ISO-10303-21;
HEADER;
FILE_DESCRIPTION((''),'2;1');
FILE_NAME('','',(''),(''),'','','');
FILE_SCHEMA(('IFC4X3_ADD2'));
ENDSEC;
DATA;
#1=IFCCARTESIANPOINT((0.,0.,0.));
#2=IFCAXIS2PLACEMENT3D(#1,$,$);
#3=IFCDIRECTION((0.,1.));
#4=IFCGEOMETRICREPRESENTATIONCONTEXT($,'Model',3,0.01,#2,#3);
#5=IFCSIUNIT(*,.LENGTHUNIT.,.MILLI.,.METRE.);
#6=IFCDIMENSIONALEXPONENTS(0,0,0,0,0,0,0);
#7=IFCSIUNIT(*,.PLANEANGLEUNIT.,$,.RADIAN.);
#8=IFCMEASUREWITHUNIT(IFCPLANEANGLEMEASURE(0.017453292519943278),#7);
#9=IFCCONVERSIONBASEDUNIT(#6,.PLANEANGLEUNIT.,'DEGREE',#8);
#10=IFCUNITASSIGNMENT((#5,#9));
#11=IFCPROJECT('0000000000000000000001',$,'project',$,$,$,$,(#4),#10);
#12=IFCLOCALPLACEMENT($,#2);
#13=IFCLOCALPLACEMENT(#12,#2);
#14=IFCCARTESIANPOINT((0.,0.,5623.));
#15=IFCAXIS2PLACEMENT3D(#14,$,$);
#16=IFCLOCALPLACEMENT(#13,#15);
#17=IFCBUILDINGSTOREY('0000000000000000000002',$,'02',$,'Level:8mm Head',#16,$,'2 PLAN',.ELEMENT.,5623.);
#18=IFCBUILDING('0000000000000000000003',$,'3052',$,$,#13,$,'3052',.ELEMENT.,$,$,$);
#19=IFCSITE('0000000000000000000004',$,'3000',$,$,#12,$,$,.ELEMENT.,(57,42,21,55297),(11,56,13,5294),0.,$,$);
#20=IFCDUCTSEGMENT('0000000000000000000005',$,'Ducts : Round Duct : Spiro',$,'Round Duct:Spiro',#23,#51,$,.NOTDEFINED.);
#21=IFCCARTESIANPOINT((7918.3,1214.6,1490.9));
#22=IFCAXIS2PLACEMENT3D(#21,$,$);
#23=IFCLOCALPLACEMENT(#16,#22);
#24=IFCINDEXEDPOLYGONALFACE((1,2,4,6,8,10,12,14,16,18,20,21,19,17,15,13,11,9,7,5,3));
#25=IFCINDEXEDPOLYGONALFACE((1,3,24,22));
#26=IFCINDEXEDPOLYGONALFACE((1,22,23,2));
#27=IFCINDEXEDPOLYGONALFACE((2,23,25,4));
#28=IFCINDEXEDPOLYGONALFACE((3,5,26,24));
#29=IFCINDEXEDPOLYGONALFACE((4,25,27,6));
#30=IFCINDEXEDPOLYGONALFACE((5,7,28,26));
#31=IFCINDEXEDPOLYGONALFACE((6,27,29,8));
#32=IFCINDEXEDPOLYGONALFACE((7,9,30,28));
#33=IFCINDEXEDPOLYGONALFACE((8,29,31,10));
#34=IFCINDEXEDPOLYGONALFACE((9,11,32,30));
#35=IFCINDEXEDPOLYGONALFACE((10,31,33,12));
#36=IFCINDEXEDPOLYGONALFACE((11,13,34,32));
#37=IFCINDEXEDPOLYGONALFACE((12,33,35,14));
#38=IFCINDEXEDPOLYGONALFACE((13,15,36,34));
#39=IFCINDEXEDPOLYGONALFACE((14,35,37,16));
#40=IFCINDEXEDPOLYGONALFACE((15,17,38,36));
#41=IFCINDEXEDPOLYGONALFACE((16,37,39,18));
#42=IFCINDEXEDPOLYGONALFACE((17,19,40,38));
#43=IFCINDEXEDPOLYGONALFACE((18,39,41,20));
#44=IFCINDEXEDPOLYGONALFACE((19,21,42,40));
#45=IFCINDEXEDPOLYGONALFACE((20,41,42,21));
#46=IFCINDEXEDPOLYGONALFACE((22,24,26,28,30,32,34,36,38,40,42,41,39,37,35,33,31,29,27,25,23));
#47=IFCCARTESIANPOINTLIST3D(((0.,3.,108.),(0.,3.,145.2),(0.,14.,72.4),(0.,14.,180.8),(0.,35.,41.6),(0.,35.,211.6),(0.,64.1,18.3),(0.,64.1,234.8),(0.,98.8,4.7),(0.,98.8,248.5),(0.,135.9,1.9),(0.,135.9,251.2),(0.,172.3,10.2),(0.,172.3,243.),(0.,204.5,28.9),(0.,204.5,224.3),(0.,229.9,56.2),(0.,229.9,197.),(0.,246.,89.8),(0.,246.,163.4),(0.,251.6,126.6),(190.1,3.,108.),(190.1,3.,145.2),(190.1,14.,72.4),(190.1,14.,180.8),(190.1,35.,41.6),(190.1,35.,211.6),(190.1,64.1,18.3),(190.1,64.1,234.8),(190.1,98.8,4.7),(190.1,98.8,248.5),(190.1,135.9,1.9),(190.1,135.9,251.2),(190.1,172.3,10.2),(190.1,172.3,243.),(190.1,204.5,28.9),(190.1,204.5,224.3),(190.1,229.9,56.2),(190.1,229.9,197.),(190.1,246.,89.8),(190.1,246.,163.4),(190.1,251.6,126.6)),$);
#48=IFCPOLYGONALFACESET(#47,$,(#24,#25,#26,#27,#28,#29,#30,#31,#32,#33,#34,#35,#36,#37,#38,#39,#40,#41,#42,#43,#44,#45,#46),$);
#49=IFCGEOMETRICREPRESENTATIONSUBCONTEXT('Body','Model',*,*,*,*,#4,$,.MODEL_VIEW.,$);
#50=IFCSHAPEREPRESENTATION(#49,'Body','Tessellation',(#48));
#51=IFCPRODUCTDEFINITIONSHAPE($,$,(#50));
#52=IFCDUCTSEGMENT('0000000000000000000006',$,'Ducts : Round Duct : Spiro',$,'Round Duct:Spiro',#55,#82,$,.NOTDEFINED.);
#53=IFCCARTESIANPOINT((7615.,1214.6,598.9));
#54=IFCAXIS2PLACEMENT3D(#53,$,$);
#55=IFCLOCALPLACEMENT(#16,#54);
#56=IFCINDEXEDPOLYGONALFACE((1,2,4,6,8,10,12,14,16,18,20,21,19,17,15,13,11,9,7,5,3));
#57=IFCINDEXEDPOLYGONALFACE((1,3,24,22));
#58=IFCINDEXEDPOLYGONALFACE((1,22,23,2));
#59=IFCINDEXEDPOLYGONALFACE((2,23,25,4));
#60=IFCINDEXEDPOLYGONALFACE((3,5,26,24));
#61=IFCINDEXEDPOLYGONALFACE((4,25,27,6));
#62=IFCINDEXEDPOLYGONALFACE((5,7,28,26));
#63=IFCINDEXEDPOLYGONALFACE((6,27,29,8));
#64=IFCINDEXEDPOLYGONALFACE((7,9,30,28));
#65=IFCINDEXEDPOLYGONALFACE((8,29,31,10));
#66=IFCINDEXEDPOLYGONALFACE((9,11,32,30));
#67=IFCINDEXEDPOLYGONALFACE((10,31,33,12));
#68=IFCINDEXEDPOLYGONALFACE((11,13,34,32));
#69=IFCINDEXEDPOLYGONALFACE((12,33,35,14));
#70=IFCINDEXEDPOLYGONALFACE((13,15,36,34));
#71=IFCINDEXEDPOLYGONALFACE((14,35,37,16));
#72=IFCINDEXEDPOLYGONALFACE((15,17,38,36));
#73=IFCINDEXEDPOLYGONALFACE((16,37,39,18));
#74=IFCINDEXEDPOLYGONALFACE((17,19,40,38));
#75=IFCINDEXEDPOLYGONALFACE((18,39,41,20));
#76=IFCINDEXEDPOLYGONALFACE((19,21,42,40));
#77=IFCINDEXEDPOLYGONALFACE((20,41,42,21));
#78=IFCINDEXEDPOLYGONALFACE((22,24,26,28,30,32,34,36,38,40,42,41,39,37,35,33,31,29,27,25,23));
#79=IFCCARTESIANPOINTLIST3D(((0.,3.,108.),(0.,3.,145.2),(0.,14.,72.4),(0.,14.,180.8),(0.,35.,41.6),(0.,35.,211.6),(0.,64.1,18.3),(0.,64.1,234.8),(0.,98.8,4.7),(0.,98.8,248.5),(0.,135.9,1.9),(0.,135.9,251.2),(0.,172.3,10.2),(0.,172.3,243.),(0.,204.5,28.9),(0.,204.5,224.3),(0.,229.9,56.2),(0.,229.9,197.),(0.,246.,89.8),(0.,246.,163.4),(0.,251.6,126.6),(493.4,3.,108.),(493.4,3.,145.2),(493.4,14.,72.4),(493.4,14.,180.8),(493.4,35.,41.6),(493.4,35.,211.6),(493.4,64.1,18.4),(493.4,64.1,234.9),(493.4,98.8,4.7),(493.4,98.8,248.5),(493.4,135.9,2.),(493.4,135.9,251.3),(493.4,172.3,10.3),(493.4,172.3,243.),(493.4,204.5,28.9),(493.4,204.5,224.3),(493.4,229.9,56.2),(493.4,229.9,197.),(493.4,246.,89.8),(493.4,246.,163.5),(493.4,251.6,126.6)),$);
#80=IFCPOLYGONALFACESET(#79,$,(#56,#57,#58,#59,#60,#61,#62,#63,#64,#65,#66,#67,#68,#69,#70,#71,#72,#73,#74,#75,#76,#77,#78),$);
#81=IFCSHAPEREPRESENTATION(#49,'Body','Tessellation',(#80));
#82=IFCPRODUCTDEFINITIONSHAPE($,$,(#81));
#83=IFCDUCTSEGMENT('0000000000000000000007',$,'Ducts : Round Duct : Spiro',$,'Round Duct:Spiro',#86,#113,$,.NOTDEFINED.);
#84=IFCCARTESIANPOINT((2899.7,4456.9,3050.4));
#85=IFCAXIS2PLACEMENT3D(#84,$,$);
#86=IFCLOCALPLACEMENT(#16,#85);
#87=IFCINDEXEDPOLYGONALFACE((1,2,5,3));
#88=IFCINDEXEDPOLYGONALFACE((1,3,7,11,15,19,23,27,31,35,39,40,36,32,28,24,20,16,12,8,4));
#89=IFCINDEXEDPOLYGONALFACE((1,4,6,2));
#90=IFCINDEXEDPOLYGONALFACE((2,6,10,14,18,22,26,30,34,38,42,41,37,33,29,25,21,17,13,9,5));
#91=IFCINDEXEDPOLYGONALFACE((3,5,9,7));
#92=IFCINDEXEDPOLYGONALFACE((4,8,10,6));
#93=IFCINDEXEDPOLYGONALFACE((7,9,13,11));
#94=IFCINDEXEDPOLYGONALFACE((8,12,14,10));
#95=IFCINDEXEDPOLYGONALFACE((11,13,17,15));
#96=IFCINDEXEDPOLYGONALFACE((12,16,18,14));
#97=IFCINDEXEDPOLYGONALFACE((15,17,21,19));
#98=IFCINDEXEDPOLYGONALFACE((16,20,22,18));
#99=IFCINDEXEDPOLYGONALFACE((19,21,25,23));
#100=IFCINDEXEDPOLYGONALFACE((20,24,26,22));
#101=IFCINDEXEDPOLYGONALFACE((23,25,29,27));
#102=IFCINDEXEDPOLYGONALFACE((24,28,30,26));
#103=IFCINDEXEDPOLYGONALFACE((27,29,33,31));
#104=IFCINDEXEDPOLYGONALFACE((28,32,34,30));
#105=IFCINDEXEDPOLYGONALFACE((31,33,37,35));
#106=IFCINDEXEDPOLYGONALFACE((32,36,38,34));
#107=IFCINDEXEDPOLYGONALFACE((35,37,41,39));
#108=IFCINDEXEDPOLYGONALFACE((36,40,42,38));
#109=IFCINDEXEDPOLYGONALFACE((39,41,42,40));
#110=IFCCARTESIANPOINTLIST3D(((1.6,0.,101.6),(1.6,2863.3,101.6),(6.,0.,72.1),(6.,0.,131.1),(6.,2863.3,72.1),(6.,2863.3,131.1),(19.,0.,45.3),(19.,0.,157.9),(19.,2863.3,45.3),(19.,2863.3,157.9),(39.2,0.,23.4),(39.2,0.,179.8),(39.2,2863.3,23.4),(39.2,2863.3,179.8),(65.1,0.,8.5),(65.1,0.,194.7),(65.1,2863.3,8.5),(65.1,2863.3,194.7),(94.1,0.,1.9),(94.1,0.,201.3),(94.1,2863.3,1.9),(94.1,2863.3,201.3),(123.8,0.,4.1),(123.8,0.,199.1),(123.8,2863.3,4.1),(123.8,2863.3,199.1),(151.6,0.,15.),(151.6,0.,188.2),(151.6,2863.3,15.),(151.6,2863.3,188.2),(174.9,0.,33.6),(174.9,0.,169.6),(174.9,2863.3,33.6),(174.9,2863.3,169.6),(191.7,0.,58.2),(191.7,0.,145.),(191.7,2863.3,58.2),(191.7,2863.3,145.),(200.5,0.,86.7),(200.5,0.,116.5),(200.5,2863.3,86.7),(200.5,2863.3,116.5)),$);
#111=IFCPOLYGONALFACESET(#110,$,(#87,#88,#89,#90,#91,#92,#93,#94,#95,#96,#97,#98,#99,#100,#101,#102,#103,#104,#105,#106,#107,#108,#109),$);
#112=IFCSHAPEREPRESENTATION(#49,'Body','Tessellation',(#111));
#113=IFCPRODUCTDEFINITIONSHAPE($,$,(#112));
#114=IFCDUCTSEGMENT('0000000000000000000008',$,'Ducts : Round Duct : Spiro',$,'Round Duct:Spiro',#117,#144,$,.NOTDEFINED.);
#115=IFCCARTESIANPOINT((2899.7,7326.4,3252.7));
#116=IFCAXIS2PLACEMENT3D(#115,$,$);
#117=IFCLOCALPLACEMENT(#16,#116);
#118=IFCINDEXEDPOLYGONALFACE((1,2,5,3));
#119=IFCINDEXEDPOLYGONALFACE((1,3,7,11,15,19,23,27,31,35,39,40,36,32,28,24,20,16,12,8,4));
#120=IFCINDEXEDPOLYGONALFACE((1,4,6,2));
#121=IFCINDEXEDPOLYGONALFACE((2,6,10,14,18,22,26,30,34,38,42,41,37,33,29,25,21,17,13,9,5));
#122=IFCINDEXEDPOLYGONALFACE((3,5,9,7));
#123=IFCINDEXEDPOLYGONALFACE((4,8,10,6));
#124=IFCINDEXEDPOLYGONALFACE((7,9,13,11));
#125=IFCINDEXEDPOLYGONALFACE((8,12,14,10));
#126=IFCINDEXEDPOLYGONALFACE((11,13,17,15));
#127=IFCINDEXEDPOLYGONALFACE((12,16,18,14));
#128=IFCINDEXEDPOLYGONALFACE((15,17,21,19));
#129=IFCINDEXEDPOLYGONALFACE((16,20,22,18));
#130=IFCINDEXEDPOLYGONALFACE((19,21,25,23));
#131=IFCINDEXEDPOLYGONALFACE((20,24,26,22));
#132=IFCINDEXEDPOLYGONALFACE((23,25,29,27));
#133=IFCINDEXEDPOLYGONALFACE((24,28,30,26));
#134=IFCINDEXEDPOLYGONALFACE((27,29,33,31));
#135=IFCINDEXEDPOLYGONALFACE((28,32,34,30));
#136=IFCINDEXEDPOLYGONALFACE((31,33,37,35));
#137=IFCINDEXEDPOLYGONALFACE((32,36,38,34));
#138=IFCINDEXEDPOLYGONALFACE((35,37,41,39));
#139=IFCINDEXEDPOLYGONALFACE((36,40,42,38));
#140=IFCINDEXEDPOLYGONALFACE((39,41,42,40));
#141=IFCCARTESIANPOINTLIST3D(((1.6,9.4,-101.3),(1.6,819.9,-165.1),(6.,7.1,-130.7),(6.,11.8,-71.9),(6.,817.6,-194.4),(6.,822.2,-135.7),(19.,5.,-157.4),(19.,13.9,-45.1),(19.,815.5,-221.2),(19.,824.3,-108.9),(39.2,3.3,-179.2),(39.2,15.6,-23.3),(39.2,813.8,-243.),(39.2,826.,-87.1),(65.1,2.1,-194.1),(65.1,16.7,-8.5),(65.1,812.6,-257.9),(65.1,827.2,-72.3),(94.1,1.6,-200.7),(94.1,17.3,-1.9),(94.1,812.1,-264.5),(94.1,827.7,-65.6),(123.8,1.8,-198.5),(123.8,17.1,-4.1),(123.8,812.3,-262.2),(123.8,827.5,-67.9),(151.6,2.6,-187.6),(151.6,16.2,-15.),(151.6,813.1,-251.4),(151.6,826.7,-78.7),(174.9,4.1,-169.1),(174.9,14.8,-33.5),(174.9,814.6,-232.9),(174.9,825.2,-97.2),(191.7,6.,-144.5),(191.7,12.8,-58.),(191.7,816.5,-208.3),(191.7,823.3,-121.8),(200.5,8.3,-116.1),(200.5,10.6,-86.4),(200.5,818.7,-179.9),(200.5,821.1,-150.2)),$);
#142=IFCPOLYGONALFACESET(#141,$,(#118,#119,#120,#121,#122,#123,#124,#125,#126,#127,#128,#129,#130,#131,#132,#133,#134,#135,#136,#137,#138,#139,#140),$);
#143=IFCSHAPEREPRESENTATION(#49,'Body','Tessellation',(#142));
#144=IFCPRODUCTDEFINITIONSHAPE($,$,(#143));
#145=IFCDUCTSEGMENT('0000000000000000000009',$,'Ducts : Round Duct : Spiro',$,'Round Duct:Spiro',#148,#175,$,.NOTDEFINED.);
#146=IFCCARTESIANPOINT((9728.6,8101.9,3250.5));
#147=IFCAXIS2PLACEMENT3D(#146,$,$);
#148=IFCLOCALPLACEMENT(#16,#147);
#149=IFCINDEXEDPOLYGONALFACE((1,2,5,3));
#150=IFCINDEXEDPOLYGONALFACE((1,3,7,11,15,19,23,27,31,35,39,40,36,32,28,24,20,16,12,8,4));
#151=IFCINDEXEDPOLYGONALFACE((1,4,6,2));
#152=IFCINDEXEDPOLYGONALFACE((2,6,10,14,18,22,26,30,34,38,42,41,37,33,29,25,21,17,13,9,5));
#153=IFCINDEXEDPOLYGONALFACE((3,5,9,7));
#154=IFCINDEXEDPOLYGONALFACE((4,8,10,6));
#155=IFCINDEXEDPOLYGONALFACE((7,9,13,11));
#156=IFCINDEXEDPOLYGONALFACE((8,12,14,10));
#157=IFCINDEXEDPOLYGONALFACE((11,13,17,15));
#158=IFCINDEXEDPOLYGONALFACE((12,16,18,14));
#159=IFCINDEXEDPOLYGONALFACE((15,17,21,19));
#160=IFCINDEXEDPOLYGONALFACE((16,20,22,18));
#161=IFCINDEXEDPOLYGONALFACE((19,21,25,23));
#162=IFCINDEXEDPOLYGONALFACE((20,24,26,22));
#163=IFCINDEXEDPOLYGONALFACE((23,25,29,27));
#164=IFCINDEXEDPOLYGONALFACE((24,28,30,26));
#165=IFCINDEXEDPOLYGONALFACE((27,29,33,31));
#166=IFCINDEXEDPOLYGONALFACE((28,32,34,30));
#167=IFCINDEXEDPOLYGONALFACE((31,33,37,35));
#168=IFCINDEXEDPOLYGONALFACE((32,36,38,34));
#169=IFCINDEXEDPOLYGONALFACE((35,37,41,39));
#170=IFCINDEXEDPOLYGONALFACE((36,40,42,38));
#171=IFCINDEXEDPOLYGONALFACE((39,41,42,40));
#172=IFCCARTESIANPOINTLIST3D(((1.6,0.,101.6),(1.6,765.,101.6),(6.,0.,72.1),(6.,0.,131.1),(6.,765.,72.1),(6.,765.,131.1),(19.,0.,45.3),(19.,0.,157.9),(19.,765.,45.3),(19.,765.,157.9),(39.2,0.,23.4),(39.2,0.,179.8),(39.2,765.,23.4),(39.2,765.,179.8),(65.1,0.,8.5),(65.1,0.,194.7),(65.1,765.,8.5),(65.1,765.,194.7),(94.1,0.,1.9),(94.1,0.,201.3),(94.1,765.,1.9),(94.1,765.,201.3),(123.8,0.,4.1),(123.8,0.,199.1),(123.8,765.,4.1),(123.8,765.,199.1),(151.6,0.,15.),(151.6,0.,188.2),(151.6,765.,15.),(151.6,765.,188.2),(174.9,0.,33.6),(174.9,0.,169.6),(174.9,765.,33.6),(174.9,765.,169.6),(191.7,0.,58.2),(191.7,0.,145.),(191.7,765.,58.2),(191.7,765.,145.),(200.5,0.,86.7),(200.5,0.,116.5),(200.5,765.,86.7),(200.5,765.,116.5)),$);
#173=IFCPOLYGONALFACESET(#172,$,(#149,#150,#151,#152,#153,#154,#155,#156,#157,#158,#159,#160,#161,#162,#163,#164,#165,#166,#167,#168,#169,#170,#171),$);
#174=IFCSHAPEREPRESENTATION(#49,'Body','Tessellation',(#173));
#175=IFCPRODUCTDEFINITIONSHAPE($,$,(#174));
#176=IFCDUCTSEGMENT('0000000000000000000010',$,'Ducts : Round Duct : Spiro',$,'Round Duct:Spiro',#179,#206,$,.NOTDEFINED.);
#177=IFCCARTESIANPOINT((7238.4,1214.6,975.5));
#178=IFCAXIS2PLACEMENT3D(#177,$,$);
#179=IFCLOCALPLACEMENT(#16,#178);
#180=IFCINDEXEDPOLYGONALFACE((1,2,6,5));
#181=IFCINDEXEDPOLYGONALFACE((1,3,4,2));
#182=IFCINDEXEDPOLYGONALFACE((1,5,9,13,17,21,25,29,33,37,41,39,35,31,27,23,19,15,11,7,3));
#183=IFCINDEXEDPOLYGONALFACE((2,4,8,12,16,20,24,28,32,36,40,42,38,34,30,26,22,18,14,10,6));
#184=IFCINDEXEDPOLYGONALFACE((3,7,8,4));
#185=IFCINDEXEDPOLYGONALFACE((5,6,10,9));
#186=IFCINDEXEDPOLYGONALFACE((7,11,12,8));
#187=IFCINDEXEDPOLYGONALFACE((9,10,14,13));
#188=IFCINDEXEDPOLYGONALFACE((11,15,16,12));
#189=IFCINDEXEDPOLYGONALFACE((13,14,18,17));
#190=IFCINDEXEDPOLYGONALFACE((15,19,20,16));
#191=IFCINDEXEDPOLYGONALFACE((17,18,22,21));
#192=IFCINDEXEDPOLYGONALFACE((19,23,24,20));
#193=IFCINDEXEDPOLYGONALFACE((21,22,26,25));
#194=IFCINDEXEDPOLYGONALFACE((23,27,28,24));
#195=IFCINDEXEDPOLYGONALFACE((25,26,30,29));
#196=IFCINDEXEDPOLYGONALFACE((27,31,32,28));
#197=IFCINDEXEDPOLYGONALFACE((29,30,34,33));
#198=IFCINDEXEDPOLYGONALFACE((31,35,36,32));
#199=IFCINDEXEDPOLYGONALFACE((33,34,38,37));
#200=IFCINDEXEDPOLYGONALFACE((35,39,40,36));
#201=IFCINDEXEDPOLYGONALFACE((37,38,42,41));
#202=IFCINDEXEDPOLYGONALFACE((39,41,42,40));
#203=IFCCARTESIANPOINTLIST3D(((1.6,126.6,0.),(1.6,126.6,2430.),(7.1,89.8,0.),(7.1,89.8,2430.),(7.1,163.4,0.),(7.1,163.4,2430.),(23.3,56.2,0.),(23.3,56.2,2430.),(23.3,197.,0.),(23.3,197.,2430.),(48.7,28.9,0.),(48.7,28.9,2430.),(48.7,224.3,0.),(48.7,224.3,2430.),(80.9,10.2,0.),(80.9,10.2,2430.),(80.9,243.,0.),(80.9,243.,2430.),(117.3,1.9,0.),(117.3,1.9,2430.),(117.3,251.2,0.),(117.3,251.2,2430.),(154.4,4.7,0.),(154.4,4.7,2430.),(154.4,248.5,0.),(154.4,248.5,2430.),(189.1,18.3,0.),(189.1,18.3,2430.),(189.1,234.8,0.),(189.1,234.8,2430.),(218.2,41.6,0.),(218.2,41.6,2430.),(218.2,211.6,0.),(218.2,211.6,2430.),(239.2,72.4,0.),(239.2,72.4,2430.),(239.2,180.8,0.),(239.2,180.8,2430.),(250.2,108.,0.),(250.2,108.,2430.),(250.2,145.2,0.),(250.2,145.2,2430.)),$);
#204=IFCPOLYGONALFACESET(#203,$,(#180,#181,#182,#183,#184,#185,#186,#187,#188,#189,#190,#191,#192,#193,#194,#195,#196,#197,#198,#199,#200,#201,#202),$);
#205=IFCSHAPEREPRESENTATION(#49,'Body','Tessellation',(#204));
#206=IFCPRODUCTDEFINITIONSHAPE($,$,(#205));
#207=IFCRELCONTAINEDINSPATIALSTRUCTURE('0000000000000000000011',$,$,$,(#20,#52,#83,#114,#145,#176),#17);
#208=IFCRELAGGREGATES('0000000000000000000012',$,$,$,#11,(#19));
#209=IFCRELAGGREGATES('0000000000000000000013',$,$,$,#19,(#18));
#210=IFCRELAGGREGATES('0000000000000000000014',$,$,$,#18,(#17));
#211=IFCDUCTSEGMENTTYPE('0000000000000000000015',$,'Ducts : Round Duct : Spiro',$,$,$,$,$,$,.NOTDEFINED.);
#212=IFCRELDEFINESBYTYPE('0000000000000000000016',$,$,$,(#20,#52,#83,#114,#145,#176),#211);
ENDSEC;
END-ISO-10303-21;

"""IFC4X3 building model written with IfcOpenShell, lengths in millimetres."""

from ifc_helpers import new_model, entity, si_unit, converted_unit, direction, frame, frame_2d, origin, origin_2d_with_axis, place, context, subcontext, project, spatial, circle, extrude, type_object, element, save


model = new_model("IFC4X3")

# Units and contexts
model_context = context("Model", 3, precision=0.01, world=origin(), true_north=direction((0.0, 1.0)))
body_context = subcontext(model_context, "Body", "Model", "MODEL_VIEW")
ifc_project = project(units=[si_unit("LENGTHUNIT", "METRE", prefix="MILLI"), converted_unit("PLANEANGLEUNIT", "DEGREE", entity("IfcPlaneAngleMeasure", 0.017453292519943278), si_unit("PLANEANGLEUNIT", "RADIAN"), dimensions=[0, 0, 0, 0, 0, 0, 0])], contexts=[model_context])

# Site, building, storey
site_placement = place(None, origin())
site = spatial("IfcSite", under=ifc_project, at=site_placement, Name="3000", CompositionType="ELEMENT", RefLatitude=(57, 42, 21, 55297), RefLongitude=(11, 56, 13, 5294), RefElevation=0.0)
building_placement = place(site_placement, origin())
building = spatial("IfcBuilding", under=site, at=building_placement, Name="3052", LongName="3052", CompositionType="ELEMENT")
storey_placement = place(building_placement, frame((0.0, 0.0, 5623.0)))
storey = spatial("IfcBuildingStorey", under=building, at=storey_placement, Name="02", ObjectType="Level:8mm Head", LongName="2 PLAN", CompositionType="ELEMENT", Elevation=5623.0)

# Duct segments
duct_segment_type = type_object("IfcDuctSegmentType", Name="Ducts : Round Duct : Spiro", PredefinedType="NOTDEFINED")
duct_segment_1_placement = place(storey_placement, frame((7918.3, 1214.6, 1490.9)))
element("IfcDuctSegment", 1, at=duct_segment_1_placement, inside=storey, type_object=duct_segment_type, Name="Ducts : Round Duct : Spiro", ObjectType="Round Duct:Spiro", PredefinedType="NOTDEFINED", context=body_context, shape_type="SweptSolid", body=[
    extrude(circle(Radius=125.0, at=origin_2d_with_axis()), frame((0.0, 126.6, 126.6), z_axis=(1.0, 0.0, 0.0), x_axis=(0.0, 1.0, 0.0)), (0.0, 0.0, 1.0), 190.1),
])
duct_segment_2_placement = place(storey_placement, frame((7615.0, 1214.6, 598.9)))
element("IfcDuctSegment", 2, at=duct_segment_2_placement, inside=storey, type_object=duct_segment_type, Name="Ducts : Round Duct : Spiro", ObjectType="Round Duct:Spiro", PredefinedType="NOTDEFINED", context=body_context, shape_type="SweptSolid", body=[
    extrude(circle(Radius=125.0, at=origin_2d_with_axis()), frame((0.0, 126.6, 126.6), z_axis=(1.0, 0.0, 0.000029), x_axis=(0.0, 1.0, 0.0)), (0.0, 0.0, 1.0), 493.4),
])
duct_segment_3_placement = place(storey_placement, frame((2899.7, 4456.9, 3050.4)))
element("IfcDuctSegment", 3, at=duct_segment_3_placement, inside=storey, type_object=duct_segment_type, Name="Ducts : Round Duct : Spiro", ObjectType="Round Duct:Spiro", PredefinedType="NOTDEFINED", context=body_context, shape_type="SweptSolid", body=[
    extrude(circle(Radius=100.0, at=frame_2d((0.0, 0.0), x_axis=(1.0, 0.0))), frame((101.6, 0.0, 101.6), z_axis=(0.0, 1.0, 0.0), x_axis=(-1.0, 0.0, 0.0)), (0.0, 0.0, 1.0), 2863.3),
])
duct_segment_4_placement = place(storey_placement, frame((2899.7, 7326.4, 3252.7)))
element("IfcDuctSegment", 4, at=duct_segment_4_placement, inside=storey, type_object=duct_segment_type, Name="Ducts : Round Duct : Spiro", ObjectType="Round Duct:Spiro", PredefinedType="NOTDEFINED", context=body_context, shape_type="SweptSolid", body=[
    extrude(circle(Radius=100.0, at=frame_2d((0.0, 0.0), x_axis=(1.0, 0.0))), frame((101.6, 9.4, -101.3), z_axis=(0.0, 0.996919, -0.078437), x_axis=(-1.0, 0.0, 0.0)), (0.0, 0.0, 1.0), 813.0),
])
duct_segment_5_placement = place(storey_placement, frame((9728.6, 8101.9, 3250.5)))
element("IfcDuctSegment", 5, at=duct_segment_5_placement, inside=storey, type_object=duct_segment_type, Name="Ducts : Round Duct : Spiro", ObjectType="Round Duct:Spiro", PredefinedType="NOTDEFINED", context=body_context, shape_type="SweptSolid", body=[
    extrude(circle(Radius=100.0, at=origin_2d_with_axis()), frame((101.6, 0.0, 101.6), z_axis=(0.0, 1.0, 0.0), x_axis=(-1.0, 0.0, 0.0)), (0.0, 0.0, 1.0), 765.0),
])
duct_segment_6_placement = place(storey_placement, frame((7238.4, 1214.6, 975.5)))
element("IfcDuctSegment", 6, at=duct_segment_6_placement, inside=storey, type_object=duct_segment_type, Name="Ducts : Round Duct : Spiro", ObjectType="Round Duct:Spiro", PredefinedType="NOTDEFINED", context=body_context, shape_type="SweptSolid", body=[
    extrude(circle(Radius=125.0, at=frame_2d((0.0, 0.0), x_axis=(1.0, 0.0))), frame((126.6, 126.6, 0.0), z_axis=(0.0, 0.0, 1.0), x_axis=(-1.0, 0.0, 0.0)), (0.0, 0.0, 1.0), 2430.0),
])

save(model, "model.ifc")
